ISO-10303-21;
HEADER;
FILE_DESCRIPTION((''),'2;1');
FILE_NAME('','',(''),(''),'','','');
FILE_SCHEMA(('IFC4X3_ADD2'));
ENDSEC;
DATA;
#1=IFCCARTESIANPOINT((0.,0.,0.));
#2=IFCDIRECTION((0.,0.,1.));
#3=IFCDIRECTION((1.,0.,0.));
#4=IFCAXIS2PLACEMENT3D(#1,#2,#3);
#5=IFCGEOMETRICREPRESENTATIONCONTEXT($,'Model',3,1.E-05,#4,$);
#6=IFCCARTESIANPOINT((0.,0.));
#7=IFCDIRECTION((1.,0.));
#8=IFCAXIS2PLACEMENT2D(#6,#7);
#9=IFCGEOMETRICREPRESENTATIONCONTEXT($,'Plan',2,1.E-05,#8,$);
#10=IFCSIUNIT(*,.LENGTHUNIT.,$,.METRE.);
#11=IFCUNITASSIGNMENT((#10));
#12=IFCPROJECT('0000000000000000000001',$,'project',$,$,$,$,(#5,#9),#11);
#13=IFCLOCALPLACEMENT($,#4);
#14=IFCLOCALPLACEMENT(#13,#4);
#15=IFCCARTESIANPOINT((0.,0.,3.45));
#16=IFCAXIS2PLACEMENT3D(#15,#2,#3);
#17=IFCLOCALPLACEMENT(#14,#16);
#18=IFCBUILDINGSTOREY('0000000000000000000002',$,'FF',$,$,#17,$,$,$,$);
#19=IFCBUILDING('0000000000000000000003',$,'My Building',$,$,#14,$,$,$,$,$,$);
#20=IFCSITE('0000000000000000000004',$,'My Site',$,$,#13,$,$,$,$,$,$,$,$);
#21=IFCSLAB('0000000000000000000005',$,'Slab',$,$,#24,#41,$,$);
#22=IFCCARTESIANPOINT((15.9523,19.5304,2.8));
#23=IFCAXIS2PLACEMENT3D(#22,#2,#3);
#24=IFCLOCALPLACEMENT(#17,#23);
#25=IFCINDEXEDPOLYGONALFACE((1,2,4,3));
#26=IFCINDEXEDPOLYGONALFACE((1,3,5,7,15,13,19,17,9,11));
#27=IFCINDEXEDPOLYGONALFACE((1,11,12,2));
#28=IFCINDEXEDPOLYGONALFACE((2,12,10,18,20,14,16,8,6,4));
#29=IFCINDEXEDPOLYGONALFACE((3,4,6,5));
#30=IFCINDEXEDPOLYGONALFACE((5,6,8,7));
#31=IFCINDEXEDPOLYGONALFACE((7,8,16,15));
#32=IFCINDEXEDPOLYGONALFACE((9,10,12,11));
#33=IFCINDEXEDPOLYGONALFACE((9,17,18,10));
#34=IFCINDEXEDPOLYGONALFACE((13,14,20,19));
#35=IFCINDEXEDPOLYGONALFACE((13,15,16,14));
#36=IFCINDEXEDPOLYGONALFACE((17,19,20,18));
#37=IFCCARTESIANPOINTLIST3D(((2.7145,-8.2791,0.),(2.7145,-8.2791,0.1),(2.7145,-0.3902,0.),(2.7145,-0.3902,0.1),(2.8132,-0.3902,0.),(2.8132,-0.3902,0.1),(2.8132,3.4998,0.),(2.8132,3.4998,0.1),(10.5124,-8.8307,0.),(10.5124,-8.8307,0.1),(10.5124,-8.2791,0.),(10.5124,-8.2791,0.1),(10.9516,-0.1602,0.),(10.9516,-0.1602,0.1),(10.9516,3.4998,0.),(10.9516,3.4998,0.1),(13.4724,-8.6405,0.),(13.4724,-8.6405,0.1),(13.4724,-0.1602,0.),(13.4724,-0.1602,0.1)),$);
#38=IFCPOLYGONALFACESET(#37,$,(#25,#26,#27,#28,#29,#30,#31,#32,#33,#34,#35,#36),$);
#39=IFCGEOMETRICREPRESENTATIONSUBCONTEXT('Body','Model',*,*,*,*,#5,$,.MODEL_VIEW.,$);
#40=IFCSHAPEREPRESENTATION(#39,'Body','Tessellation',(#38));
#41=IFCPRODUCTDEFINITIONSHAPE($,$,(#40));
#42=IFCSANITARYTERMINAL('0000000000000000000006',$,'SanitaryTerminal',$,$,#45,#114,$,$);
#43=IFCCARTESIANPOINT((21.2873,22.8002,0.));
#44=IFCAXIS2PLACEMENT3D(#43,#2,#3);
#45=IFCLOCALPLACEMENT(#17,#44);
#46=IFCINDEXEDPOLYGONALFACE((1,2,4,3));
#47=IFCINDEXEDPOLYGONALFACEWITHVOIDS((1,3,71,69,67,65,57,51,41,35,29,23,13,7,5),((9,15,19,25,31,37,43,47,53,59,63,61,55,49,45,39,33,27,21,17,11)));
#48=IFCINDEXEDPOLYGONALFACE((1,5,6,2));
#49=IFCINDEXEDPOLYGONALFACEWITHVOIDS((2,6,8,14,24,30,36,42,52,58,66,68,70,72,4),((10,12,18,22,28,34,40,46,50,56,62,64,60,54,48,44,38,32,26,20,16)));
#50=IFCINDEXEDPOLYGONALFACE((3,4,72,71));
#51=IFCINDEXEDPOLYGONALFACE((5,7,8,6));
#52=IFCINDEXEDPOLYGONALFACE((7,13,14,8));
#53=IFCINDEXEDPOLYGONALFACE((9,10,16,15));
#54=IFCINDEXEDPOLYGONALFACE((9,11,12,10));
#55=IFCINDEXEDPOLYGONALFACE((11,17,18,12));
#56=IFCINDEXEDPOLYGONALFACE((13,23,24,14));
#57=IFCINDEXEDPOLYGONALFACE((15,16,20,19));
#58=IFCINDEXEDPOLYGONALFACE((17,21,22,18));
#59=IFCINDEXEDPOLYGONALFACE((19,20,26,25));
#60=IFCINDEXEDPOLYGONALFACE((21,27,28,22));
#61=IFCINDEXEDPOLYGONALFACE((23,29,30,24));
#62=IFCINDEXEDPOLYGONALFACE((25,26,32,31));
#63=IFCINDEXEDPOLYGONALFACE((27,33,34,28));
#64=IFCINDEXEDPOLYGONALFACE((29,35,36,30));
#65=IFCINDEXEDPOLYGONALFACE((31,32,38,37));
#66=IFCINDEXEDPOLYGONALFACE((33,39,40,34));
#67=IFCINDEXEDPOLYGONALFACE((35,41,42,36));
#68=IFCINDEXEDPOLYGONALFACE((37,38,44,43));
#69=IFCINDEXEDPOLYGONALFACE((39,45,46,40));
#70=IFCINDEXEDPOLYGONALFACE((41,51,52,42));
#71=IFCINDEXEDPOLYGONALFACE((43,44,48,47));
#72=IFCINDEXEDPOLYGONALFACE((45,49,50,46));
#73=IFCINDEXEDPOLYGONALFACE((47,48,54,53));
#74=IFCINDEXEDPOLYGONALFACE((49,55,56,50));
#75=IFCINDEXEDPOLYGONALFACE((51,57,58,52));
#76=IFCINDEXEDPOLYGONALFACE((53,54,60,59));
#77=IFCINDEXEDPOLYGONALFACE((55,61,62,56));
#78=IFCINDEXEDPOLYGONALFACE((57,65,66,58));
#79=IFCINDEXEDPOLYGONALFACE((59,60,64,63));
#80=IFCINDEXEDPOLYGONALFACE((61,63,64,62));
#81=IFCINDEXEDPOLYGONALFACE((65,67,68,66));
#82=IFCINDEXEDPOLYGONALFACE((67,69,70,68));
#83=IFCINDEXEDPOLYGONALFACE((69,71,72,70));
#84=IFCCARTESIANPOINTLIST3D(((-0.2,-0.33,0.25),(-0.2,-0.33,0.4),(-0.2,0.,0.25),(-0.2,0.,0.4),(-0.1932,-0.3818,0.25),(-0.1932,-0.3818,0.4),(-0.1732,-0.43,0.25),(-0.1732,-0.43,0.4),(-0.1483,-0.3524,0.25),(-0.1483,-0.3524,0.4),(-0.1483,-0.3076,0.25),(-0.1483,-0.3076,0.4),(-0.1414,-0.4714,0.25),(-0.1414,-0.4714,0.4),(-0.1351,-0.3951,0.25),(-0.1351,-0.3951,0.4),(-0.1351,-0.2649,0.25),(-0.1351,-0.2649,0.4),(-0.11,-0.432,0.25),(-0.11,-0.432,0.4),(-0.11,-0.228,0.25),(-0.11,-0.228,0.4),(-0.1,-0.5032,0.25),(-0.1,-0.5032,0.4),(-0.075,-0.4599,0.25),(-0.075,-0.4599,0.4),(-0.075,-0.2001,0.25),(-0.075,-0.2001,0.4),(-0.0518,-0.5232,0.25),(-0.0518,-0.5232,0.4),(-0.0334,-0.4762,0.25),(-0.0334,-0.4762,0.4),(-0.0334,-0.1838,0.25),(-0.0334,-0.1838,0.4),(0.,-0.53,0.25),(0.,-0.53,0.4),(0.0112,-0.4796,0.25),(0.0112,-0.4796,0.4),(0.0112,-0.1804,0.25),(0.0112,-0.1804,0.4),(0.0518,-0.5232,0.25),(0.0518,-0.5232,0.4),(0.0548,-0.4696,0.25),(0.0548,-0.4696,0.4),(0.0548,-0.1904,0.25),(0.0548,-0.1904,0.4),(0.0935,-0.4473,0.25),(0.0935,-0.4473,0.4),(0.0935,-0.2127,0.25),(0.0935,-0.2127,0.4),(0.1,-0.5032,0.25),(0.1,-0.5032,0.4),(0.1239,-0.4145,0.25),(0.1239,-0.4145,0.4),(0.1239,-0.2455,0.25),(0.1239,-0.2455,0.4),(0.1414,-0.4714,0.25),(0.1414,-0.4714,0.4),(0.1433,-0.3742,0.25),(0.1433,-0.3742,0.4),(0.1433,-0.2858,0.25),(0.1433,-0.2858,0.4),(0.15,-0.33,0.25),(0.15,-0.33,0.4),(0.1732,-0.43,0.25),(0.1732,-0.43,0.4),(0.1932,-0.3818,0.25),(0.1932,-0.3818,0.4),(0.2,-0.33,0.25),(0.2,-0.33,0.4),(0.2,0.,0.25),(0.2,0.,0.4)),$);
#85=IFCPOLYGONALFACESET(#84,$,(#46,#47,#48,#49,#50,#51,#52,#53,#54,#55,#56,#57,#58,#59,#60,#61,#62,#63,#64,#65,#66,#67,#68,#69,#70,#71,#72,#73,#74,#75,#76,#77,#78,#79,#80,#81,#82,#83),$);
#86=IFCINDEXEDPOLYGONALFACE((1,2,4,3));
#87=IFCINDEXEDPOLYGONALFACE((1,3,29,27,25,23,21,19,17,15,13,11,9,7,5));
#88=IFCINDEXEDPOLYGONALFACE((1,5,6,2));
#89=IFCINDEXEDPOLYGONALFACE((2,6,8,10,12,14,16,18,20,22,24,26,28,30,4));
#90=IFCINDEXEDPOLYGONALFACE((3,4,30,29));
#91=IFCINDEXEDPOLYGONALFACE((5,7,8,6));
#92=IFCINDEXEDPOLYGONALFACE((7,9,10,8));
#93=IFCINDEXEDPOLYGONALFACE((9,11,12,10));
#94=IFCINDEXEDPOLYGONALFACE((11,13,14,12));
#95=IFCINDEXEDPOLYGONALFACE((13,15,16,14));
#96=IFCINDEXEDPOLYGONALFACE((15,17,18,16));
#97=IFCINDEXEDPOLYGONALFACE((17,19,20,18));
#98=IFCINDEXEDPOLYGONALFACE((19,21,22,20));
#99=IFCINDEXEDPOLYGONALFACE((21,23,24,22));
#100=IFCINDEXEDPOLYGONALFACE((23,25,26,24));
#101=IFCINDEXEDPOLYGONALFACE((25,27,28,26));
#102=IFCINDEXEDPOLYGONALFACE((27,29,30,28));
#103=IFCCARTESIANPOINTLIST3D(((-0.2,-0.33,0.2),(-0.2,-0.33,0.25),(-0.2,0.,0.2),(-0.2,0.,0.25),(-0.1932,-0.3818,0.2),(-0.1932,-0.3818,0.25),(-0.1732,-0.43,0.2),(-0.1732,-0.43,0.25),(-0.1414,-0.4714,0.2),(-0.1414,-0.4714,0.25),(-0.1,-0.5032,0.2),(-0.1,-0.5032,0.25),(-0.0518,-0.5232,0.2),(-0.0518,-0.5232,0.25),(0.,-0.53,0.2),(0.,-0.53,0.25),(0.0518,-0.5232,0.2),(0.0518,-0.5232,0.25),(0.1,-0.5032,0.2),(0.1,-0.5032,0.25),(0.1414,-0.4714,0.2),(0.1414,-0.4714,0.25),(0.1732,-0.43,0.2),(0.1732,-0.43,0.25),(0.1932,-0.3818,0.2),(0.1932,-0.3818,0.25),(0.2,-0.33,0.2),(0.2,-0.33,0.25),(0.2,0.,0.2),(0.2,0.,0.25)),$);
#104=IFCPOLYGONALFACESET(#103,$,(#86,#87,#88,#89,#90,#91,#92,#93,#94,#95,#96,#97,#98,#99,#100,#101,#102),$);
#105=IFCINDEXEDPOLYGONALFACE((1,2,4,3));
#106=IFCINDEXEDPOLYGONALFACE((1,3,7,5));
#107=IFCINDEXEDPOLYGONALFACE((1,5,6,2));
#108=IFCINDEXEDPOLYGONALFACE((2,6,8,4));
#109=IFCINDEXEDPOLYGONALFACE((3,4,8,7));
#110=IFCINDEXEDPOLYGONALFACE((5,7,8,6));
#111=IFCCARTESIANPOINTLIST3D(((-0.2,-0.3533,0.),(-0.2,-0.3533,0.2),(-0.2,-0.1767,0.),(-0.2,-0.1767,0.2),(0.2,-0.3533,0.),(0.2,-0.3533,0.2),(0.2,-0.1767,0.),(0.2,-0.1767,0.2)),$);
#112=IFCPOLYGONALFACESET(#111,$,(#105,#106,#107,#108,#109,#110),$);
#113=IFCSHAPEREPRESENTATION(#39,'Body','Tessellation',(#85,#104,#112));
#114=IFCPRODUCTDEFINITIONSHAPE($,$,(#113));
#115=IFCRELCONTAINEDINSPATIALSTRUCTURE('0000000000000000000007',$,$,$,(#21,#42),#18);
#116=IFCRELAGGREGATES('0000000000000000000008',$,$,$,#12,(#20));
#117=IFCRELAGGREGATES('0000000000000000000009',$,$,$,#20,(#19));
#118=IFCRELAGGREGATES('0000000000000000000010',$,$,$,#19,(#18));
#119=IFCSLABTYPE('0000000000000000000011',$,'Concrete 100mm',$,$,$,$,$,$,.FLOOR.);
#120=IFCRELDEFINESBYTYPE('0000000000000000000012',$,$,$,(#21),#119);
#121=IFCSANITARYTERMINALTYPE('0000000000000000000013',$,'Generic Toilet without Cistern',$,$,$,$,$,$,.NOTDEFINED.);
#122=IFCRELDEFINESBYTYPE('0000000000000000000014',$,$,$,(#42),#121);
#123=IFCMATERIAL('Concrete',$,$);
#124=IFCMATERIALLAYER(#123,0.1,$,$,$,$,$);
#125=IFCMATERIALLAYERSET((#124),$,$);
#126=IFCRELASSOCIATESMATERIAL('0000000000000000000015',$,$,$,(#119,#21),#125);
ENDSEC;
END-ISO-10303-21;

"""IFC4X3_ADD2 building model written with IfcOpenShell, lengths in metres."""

from ifc_helpers import new_model, entity, si_unit, frame, frame_2d, origin_with_axes, origin_2d_with_axis, place, context, subcontext, project, spatial, line, arc, indexed_curve, circle_curve, outline, extrude, shape, source, transform, mapped, material, layer, layer_set, layer_usage, type_object, type_shapes, element, save


model = new_model("IFC4X3_ADD2")

# Units and contexts
model_context = context("Model", 3, precision=1e-05, world=origin_with_axes())
plan_context = context("Plan", 2, precision=1e-05, world=origin_2d_with_axis())
body_context_1 = subcontext(model_context, "Body", "Model", "MODEL_VIEW")
body_context_2 = subcontext(plan_context, "Body", "Plan", "PLAN_VIEW")
ifc_project = project(units=[si_unit("LENGTHUNIT", "METRE")], contexts=[model_context, plan_context])

# Site, building, storey
site_placement = place(None, origin_with_axes())
site = spatial("IfcSite", under=ifc_project, at=site_placement, Name="My Site")
building_placement = place(site_placement, origin_with_axes())
building = spatial("IfcBuilding", under=site, at=building_placement, Name="My Building")
storey_placement = place(building_placement, frame((0.0, 0.0, 3.45), z_axis=(0.0, 0.0, 1.0), x_axis=(1.0, 0.0, 0.0)))
storey = spatial("IfcBuildingStorey", under=building, at=storey_placement, Name="FF")

# Slab
ifc_material_1 = material(Name="Concrete")
ifc_layer_1 = layer(ifc_material_1, 0.1)
ifc_layer_set_1 = layer_set([ifc_layer_1])
ifc_layer_usage_1 = layer_usage(ifc_layer_set_1, "AXIS3", "POSITIVE", 0.0)
slab_type = type_object("IfcSlabType", Name="Concrete 100mm", PredefinedType="FLOOR", material=ifc_layer_set_1)
slab_placement = place(storey_placement, frame((15.9523, 19.5304, 2.8), z_axis=(0.0, 0.0, 1.0), x_axis=(1.0, 0.0, 0.0)))
element("IfcSlab", 1, at=slab_placement, inside=storey, type_object=slab_type, material=ifc_layer_usage_1, Name="Slab", context=body_context_1, shape_type="SweptSolid", body=[
    extrude(outline(indexed_curve([(10.5124, -8.2791), (10.5124, -8.8307), (13.4724, -8.6405), (13.4724, -0.1602), (10.9516, -0.1602), (10.9516, 3.4998), (2.8132, 3.4998), (2.8132, -0.3902), (2.7145, -0.3902), (2.7145, -8.2791)], segments=[line(3, 2), line(2, 1), line(1, 10), line(10, 9), line(9, 8), line(8, 7), line(7, 6), line(6, 5), line(5, 4), line(4, 3)], self_intersect=False)), None, (0.0, 0.0, 1.0), 0.1),
])

# Sanitary terminal
sanitary_terminal_type_1 = type_object("IfcSanitaryTerminalType", Name="Generic Toilet without Cistern", PredefinedType="NOTDEFINED")
shared_shape_1 = source(origin_with_axes(), body_context_1, "Body", "SweptSolid", [
    extrude(outline(indexed_curve([(-0.2, 0.0), (0.2, 0.0), (0.2, -0.33), (0.1414, -0.4714), (0.0, -0.53), (-0.1414, -0.4714), (-0.2, -0.33)], segments=[line(1, 2), line(2, 3), arc(3, 4, 5), arc(5, 6, 7), line(7, 1)]), holes=[circle_curve(frame_2d((0.0, -0.33)), 0.15)]), frame((0.0, 0.0, 0.25), z_axis=(0.0, 0.0, 1.0), x_axis=(1.0, 0.0, 0.0)), (0.0, 0.0, 1.0), 0.15),
    extrude(outline(indexed_curve([(-0.2, 0.0), (0.2, 0.0), (0.2, -0.33), (0.1414, -0.4714), (0.0, -0.53), (-0.1414, -0.4714), (-0.2, -0.33)], segments=[line(1, 2), line(2, 3), arc(3, 4, 5), arc(5, 6, 7), line(7, 1)])), frame((0.0, 0.0, 0.2), z_axis=(0.0, 0.0, 1.0), x_axis=(1.0, 0.0, 0.0)), (0.0, 0.0, 1.0), 0.05),
    extrude(outline(indexed_curve([(-0.2, -0.1767), (0.2, -0.1767), (0.2, -0.3533), (-0.2, -0.3533)], segments=[line(1, 2, 3, 4, 1)])), origin_with_axes(), (0.0, 0.0, 1.0), 0.2),
])
shared_shape_2 = source(origin_with_axes(), body_context_2, "Body", "Annotation2D", [
    entity("IfcGeometricCurveSet", [entity("IfcIndexedPolyCurve", entity("IfcCartesianPointList2D", [[-0.1068, -0.124], [-0.0957, -0.1129], [-0.0804, -0.1088], [0.0804, -0.1088], [0.0957, -0.1129], [0.1068, -0.124], [0.1109, -0.1393], [0.1109, -0.3476], [0.1025, -0.3926], [0.0784, -0.4308], [0.0424, -0.4563], [0.0, -0.4652], [-0.0424, -0.4563], [-0.0784, -0.4308], [-0.1025, -0.3926], [-0.1109, -0.3476], [-0.1109, -0.1393]]), [entity("IfcLineIndex", [1, 2, 3, 4, 5, 6, 7, 8, 9, 10, 11, 12, 13, 14, 15, 16, 17, 1])]), entity("IfcIndexedPolyCurve", entity("IfcCartesianPointList2D", [[-0.1962, -0.2314], [-0.1848, -0.301], [-0.1764, -0.3339], [-0.1663, -0.3651], [-0.1546, -0.3944], [-0.1414, -0.4213], [-0.1269, -0.4458], [-0.1111, -0.4675], [-0.0943, -0.4862], [-0.0765, -0.5018], [-0.0581, -0.514], [-0.039, -0.5229], [-0.0196, -0.5282], [0.0, -0.53], [0.0196, -0.5282], [0.039, -0.5229], [0.0581, -0.514], [0.0765, -0.5018], [0.0943, -0.4862], [0.1111, -0.4675], [0.1269, -0.4458], [0.1414, -0.4213], [0.1546, -0.3944], [0.1663, -0.3651], [0.1764, -0.3339], [0.1848, -0.301], [0.1962, -0.2314], [0.2, -0.159], [0.1872, 0.0], [-0.1872, 0.0], [-0.2, -0.159]]), [entity("IfcLineIndex", [1, 2, 3, 4, 5, 6, 7, 8, 9, 10, 11, 12, 13, 14, 15, 16, 17, 18, 19, 20, 21, 22, 23, 24, 25, 26, 27, 28, 29, 30, 31, 1])])]),
])
type_shapes(sanitary_terminal_type_1, [shared_shape_1, shared_shape_2])
sanitary_terminal_1_placement = place(storey_placement, frame((21.2873, 22.8002, 0.0), z_axis=(0.0, 0.0, 1.0), x_axis=(1.0, 0.0, 0.0)))
element("IfcSanitaryTerminal", 2, at=sanitary_terminal_1_placement, inside=storey, type_object=sanitary_terminal_type_1, Name="SanitaryTerminal", shapes=[
    shape(body_context_1, "Body", "MappedRepresentation", [mapped(shared_shape_1, transform((0.0, 0.0, 0.0), x_axis=(1.0, 0.0, 0.0), y_axis=(0.0, 1.0, 0.0), z_axis=(0.0, 0.0, 1.0), scale=1.0))]),
    shape(body_context_2, "Body", "MappedRepresentation", [mapped(shared_shape_2, transform((0.0, 0.0, 0.0), x_axis=(1.0, 0.0, 0.0), y_axis=(0.0, 1.0, 0.0), z_axis=(0.0, 0.0, 1.0), scale=1.0))]),
])

save(model, "model.ifc")
